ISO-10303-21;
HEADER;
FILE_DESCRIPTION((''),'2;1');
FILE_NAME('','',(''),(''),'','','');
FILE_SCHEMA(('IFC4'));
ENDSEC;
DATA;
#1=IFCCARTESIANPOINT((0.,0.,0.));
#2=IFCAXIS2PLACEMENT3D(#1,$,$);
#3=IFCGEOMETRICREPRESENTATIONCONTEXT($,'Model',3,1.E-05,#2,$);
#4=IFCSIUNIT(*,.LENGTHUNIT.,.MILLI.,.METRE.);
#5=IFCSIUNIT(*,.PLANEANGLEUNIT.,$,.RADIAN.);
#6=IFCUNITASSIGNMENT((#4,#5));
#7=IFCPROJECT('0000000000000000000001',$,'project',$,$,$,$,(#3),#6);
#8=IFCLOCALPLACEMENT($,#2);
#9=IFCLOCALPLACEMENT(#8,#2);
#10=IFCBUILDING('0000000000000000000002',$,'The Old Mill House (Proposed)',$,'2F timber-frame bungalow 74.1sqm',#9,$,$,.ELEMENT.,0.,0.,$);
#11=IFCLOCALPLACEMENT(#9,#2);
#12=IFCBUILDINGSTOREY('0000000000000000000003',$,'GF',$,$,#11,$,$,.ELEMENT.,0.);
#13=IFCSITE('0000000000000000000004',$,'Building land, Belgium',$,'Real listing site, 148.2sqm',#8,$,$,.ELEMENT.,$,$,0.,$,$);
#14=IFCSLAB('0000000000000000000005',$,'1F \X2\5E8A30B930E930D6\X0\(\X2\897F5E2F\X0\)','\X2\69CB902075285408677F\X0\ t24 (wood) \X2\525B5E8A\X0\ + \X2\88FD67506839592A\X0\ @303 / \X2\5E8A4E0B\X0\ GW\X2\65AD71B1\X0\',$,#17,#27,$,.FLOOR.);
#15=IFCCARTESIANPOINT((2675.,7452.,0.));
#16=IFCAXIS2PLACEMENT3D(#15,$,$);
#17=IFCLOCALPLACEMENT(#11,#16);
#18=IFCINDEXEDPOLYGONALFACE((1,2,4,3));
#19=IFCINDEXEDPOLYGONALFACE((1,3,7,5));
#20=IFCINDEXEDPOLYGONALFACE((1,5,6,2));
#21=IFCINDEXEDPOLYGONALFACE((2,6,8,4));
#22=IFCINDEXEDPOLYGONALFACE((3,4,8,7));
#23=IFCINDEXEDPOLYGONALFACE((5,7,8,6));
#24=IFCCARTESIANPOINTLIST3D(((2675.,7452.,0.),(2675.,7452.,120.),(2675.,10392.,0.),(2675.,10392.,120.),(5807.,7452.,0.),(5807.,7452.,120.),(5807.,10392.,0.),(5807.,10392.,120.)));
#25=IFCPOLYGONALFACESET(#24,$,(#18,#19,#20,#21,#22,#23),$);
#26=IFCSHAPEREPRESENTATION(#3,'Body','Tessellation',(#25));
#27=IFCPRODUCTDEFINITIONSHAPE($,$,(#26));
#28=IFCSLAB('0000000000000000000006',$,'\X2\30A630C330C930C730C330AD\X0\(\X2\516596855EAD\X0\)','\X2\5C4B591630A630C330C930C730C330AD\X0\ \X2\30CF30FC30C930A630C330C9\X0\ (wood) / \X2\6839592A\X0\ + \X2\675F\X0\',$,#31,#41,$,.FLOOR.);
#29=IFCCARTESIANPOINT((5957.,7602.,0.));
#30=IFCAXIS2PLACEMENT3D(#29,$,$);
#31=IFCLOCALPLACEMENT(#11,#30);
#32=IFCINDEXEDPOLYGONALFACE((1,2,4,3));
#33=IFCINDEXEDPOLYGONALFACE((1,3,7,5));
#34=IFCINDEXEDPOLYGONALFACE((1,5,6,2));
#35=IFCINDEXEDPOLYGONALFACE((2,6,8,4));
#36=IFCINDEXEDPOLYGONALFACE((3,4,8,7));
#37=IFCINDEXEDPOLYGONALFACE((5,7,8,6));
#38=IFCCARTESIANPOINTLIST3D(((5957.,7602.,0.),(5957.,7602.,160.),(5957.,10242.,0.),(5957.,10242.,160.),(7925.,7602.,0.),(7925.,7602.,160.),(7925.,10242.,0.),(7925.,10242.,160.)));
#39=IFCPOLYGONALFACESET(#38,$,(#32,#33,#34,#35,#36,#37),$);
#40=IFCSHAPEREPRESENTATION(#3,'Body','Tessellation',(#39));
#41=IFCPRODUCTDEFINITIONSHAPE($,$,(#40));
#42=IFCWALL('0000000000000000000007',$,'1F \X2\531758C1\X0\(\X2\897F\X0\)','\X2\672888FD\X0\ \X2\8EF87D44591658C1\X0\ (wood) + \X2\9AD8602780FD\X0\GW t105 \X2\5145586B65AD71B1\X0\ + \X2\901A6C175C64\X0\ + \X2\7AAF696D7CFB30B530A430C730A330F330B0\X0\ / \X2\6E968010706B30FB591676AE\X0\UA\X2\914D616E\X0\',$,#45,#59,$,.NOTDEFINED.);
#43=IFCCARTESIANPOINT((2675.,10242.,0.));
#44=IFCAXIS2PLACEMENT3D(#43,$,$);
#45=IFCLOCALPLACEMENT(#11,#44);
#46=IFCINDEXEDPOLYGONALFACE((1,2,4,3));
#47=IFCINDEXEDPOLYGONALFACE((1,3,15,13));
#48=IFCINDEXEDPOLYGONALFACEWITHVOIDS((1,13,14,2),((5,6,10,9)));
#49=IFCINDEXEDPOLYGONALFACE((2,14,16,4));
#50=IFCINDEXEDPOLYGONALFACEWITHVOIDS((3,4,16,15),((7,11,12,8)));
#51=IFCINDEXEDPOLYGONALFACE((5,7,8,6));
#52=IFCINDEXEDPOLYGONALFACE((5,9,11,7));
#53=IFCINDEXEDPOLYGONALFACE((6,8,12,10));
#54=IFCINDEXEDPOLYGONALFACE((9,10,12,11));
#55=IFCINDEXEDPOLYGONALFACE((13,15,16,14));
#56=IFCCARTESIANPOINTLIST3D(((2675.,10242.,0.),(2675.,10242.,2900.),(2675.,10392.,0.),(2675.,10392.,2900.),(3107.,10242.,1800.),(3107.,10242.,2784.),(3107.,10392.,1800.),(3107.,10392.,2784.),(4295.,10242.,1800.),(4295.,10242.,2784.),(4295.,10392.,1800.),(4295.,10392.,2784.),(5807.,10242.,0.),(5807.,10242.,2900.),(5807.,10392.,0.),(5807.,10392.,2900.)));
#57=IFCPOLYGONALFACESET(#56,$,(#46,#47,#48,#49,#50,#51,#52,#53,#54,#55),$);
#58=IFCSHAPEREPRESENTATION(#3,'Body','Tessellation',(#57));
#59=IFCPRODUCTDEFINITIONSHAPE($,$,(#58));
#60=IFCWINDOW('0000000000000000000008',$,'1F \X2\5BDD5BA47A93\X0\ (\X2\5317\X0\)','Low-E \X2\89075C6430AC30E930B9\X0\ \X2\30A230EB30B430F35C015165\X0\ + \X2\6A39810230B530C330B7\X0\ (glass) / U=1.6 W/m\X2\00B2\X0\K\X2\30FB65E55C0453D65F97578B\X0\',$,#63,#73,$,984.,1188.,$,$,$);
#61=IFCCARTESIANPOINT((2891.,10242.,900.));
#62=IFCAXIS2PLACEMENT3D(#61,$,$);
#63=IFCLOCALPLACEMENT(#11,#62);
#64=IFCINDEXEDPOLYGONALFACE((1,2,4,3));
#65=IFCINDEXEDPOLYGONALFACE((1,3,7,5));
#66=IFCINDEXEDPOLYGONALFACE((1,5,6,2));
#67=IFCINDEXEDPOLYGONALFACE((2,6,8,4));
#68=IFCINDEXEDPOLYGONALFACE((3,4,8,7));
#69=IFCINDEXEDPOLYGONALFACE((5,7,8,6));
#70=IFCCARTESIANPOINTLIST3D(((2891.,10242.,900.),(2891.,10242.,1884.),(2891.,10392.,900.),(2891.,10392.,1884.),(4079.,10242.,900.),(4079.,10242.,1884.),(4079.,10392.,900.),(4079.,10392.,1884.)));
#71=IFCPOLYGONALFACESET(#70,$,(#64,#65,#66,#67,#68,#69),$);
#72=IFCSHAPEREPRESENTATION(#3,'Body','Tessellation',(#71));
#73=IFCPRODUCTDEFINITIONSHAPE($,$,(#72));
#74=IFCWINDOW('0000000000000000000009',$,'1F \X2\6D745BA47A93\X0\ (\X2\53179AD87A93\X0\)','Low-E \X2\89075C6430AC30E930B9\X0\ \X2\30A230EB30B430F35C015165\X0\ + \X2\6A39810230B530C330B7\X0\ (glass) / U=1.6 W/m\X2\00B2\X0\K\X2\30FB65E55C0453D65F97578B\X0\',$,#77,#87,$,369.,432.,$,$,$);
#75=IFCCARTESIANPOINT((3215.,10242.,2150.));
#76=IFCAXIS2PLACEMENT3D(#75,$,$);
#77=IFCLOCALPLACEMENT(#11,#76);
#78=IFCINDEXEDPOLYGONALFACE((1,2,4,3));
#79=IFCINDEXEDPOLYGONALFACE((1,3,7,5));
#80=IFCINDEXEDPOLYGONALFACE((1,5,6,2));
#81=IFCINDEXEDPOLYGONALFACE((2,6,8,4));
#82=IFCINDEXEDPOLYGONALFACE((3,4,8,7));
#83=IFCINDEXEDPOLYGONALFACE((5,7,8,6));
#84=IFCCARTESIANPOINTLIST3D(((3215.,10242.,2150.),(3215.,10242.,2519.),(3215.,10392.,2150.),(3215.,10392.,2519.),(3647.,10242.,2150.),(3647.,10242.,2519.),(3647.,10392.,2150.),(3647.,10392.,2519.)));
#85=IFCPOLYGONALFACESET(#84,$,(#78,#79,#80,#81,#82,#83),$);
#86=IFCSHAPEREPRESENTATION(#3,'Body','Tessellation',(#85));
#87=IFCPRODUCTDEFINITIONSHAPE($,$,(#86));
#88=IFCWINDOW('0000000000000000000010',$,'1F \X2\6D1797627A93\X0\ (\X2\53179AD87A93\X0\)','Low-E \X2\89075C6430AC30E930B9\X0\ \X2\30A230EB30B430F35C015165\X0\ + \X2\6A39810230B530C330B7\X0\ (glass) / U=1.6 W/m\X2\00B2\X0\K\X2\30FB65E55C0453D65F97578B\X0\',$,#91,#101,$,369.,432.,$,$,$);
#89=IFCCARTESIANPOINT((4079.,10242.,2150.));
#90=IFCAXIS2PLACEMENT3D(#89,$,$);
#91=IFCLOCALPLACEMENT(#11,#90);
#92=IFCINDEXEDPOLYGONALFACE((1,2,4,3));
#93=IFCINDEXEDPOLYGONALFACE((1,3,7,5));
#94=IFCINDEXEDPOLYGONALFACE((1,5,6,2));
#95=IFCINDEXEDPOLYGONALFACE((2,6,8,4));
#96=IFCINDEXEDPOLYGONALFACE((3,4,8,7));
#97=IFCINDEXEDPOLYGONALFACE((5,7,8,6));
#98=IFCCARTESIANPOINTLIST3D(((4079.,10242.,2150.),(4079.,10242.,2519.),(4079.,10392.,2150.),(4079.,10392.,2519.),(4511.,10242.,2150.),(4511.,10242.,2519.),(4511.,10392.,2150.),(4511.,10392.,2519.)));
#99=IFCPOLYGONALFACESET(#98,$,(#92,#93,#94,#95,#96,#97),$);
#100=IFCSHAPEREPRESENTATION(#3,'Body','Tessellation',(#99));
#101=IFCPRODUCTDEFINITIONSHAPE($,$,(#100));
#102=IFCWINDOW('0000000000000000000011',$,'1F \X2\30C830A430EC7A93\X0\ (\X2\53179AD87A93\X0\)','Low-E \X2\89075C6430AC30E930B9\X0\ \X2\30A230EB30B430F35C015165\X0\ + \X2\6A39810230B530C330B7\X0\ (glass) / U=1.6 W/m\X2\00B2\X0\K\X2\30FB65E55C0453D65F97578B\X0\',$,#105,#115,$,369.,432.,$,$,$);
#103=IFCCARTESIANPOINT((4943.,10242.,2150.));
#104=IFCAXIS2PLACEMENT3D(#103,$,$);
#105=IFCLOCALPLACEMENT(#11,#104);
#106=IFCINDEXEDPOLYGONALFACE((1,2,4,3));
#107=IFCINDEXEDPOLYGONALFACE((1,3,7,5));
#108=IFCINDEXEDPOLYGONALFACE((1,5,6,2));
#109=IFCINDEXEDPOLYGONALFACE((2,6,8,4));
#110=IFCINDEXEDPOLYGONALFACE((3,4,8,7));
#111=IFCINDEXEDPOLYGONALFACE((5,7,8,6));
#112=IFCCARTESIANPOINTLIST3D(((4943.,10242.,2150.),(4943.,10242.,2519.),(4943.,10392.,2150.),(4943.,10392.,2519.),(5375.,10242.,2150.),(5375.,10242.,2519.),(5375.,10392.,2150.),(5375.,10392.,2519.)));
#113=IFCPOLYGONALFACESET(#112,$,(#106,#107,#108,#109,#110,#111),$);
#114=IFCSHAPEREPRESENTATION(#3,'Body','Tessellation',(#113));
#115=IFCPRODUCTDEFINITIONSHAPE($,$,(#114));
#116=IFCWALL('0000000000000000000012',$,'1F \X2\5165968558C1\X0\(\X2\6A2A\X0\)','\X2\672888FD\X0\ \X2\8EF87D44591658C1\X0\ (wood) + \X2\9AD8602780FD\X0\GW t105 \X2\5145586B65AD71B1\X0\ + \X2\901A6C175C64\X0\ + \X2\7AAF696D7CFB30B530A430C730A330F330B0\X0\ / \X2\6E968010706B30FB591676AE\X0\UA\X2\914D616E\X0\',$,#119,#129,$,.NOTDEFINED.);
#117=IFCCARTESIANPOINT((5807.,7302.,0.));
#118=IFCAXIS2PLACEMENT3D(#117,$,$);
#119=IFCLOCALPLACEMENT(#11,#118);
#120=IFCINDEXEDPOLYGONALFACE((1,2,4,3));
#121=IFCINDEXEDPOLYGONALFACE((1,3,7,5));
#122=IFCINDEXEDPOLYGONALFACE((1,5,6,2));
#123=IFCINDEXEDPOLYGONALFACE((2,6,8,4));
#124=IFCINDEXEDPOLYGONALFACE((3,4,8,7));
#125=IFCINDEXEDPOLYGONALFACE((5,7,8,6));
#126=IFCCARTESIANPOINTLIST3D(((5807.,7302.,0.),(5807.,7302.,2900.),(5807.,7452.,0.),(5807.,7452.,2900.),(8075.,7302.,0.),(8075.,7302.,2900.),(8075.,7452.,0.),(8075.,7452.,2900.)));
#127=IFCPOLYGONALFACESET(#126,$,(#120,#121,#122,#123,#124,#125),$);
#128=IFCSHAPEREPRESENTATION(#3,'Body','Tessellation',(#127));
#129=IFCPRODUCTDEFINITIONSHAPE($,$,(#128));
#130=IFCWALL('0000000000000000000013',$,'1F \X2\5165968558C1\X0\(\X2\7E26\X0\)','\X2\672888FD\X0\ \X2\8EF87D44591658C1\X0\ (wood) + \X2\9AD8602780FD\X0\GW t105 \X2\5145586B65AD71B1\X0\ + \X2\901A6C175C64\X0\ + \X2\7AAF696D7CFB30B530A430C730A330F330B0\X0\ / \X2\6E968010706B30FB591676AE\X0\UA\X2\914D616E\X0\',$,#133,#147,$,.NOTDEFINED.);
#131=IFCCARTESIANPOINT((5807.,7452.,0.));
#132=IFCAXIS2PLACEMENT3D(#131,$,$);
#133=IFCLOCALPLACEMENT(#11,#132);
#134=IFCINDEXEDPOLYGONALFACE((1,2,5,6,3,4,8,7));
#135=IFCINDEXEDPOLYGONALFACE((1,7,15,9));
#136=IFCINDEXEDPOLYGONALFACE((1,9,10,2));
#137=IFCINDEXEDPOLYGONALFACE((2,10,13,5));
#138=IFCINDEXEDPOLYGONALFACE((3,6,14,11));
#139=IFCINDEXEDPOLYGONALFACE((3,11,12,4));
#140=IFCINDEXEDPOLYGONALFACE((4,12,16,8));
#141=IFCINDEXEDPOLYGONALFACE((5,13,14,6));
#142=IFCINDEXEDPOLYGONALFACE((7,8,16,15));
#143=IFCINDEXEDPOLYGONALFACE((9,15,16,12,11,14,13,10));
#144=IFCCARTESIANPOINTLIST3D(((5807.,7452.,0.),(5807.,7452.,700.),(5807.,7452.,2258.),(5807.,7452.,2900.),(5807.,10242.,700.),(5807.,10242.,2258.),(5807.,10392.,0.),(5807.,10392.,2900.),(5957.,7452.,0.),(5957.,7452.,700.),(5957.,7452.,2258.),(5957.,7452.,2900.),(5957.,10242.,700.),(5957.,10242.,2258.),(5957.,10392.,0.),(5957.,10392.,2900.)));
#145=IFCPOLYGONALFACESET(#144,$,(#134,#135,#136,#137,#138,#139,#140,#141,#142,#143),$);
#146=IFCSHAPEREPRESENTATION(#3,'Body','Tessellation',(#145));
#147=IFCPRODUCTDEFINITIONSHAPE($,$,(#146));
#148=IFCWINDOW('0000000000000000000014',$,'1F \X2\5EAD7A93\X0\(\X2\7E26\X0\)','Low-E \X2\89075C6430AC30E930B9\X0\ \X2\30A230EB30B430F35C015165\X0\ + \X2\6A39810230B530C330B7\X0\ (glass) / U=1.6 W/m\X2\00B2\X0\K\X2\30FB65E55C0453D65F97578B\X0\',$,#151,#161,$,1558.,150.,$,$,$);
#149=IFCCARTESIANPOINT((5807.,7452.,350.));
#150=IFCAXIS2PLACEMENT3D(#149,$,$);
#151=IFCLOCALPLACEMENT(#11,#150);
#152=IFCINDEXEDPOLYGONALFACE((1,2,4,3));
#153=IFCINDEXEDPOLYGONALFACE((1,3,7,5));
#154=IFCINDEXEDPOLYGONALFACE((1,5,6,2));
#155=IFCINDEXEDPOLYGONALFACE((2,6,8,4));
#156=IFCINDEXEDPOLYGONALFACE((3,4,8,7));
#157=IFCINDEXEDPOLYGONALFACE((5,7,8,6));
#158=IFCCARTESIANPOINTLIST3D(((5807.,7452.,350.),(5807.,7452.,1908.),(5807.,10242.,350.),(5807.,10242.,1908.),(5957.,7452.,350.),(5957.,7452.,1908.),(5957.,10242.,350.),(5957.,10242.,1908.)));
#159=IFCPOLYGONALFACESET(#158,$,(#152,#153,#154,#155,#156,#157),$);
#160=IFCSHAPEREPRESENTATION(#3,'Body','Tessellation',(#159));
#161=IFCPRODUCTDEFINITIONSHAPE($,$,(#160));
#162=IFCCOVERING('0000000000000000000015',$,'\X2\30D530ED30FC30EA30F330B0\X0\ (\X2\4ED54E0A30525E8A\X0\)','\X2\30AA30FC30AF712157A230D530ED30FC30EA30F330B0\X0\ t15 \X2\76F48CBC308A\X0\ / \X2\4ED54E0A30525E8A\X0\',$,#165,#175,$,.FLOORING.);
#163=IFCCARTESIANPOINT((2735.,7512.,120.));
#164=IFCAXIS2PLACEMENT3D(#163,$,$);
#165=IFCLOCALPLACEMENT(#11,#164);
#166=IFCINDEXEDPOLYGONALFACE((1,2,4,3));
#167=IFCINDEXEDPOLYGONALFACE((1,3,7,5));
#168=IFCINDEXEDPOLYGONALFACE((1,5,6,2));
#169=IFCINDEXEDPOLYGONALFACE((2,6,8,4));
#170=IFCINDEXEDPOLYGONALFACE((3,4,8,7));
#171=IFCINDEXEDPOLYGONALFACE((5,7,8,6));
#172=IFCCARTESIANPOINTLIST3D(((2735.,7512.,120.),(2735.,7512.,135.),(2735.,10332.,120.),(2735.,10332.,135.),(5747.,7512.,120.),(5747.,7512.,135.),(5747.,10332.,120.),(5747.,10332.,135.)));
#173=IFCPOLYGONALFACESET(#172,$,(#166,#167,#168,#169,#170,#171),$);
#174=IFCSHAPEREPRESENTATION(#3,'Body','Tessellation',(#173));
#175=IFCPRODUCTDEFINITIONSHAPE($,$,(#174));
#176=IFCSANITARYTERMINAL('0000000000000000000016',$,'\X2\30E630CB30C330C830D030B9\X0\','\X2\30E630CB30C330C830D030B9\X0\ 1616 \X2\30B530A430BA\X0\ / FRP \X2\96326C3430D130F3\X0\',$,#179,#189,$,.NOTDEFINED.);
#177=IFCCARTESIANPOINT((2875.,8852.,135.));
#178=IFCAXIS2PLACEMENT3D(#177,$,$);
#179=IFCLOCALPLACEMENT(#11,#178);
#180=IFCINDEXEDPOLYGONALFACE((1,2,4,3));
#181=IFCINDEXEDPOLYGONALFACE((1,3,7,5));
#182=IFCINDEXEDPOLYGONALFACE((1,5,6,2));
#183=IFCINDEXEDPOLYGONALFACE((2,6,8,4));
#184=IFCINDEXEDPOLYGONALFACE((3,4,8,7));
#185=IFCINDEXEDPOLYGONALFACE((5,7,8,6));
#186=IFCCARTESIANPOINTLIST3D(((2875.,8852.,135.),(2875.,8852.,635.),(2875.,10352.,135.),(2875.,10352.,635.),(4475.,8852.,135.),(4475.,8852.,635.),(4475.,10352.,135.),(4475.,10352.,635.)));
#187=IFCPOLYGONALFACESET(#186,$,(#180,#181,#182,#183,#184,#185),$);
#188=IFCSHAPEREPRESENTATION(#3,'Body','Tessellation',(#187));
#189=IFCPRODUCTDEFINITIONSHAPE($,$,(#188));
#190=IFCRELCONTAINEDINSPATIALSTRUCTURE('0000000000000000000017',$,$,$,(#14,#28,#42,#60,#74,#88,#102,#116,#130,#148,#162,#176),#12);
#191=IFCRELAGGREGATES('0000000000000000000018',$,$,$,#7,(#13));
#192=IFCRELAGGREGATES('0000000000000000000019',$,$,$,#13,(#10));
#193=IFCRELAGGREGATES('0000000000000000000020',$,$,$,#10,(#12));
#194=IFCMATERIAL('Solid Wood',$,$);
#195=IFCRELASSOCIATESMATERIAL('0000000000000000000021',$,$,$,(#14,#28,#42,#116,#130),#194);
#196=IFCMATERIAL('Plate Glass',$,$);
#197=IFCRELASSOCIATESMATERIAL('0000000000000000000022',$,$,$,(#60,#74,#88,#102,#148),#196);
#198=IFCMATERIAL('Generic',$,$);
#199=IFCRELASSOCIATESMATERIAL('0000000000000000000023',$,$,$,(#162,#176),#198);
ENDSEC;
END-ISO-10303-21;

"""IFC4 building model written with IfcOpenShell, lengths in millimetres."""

from ifc_helpers import new_model, si_unit, frame, frame_2d, origin, place, context, project, spatial, rectangle, extrude, material, element, fill, save


model = new_model("IFC4")

# Units and contexts
model_context = context("Model", 3, precision=1e-05, world=origin())
ifc_project = project(units=[si_unit("LENGTHUNIT", "METRE", prefix="MILLI"), si_unit("PLANEANGLEUNIT", "RADIAN")], contexts=[model_context])

# Site, building, storey
site_placement = place(None, origin())
site = spatial("IfcSite", under=ifc_project, at=site_placement, Name="Building land, Belgium", ObjectType="Real listing site, 148.2sqm", CompositionType="ELEMENT", RefElevation=0.0)
building_placement = place(site_placement, origin())
building = spatial("IfcBuilding", under=site, at=building_placement, Name="The Old Mill House (Proposed)", ObjectType="2F timber-frame bungalow 74.1sqm", CompositionType="ELEMENT", ElevationOfRefHeight=0.0, ElevationOfTerrain=0.0)
storey_placement = place(building_placement, origin())
storey = spatial("IfcBuildingStorey", under=building, at=storey_placement, Name="GF", CompositionType="ELEMENT", Elevation=0.0)

# Slabs
ifc_material_1 = material(Name="Solid Wood")
slab_1_placement = place(storey_placement, frame((2675.0, 7452.0, 0.0)))
element("IfcSlab", 1, at=slab_1_placement, inside=storey, material=ifc_material_1, Name="1F 床スラブ(西帯)", Description="構造用合板 t24 (wood) 剛床 + 製材根太 @303 / 床下 GW断熱", PredefinedType="FLOOR", context=model_context, shape_type="SweptSolid", body=[
    extrude(rectangle(XDim=3132.0, YDim=2940.0, at=frame_2d((1566.0, 1470.0))), frame((2675.0, 7452.0, 0.0)), (0.0, 0.0, 1.0), 120.0),
])
slab_2_placement = place(storey_placement, frame((5957.0, 7602.0, 0.0)))
element("IfcSlab", 2, at=slab_2_placement, inside=storey, material=ifc_material_1, Name="ウッドデッキ(入隅庭)", Description="屋外ウッドデッキ ハードウッド (wood) / 根太 + 束", PredefinedType="FLOOR", context=model_context, shape_type="SweptSolid", body=[
    extrude(rectangle(XDim=1968.0, YDim=2640.0, at=frame_2d((984.0, 1320.0))), frame((5957.0, 7602.0, 0.0)), (0.0, 0.0, 1.0), 160.0),
])

# Wall, openings, windows
wall_1_placement = place(storey_placement, frame((2675.0, 10242.0, 0.0)))
wall_1 = element("IfcWall", 3, at=wall_1_placement, inside=storey, material=ifc_material_1, Name="1F 北壁(西)", Description="木製 軸組外壁 (wood) + 高性能GW t105 充填断熱 + 通気層 + 窯業系サイディング / 準耐火・外皮UA配慮", PredefinedType="NOTDEFINED", context=model_context, shape_type="SweptSolid", body=[
    extrude(rectangle(XDim=3132.0, YDim=150.0, at=frame_2d((1566.0, 75.0))), frame((2675.0, 10242.0, 0.0)), (0.0, 0.0, 1.0), 2900.0),
])
opening_1_placement = place(storey_placement, frame((2891.0, 10242.0, 900.0)))
opening_1 = element("IfcOpeningElement", 4, at=opening_1_placement, cuts=wall_1, PredefinedType="NOTDEFINED", context=model_context, shape_type="SweptSolid", body=[
    extrude(rectangle(XDim=1188.0, YDim=150.0, at=frame_2d((594.0, 75.0))), frame((2891.0, 10242.0, 900.0)), (0.0, 0.0, 1.0), 984.0),
])
opening_2_placement = place(storey_placement, frame((3215.0, 10242.0, 2150.0)))
opening_2 = element("IfcOpeningElement", 5, at=opening_2_placement, cuts=wall_1, PredefinedType="NOTDEFINED", context=model_context, shape_type="SweptSolid", body=[
    extrude(rectangle(XDim=432.0, YDim=150.0, at=frame_2d((216.0, 75.0))), frame((3215.0, 10242.0, 2150.0)), (0.0, 0.0, 1.0), 369.0),
])
opening_3_placement = place(storey_placement, frame((4079.0, 10242.0, 2150.0)))
opening_3 = element("IfcOpeningElement", 6, at=opening_3_placement, cuts=wall_1, PredefinedType="NOTDEFINED", context=model_context, shape_type="SweptSolid", body=[
    extrude(rectangle(XDim=432.0, YDim=150.0, at=frame_2d((216.0, 75.0))), frame((4079.0, 10242.0, 2150.0)), (0.0, 0.0, 1.0), 369.0),
])
opening_4_placement = place(storey_placement, frame((4943.0, 10242.0, 2150.0)))
opening_4 = element("IfcOpeningElement", 7, at=opening_4_placement, cuts=wall_1, PredefinedType="NOTDEFINED", context=model_context, shape_type="SweptSolid", body=[
    extrude(rectangle(XDim=432.0, YDim=150.0, at=frame_2d((216.0, 75.0))), frame((4943.0, 10242.0, 2150.0)), (0.0, 0.0, 1.0), 369.0),
])
ifc_material_2 = material(Name="Plate Glass")
window_1_placement = place(storey_placement, frame((2891.0, 10242.0, 900.0)))
window_1 = element("IfcWindow", 8, at=window_1_placement, inside=storey, material=ifc_material_2, Name="1F 寝室窓 (北)", Description="Low-E 複層ガラス アルゴン封入 + 樹脂サッシ (glass) / U=1.6 W/m²K・日射取得型", OverallHeight=984.0, OverallWidth=1188.0, context=model_context, shape_type="SweptSolid", body=[
    extrude(rectangle(XDim=1188.0, YDim=150.0, at=frame_2d((594.0, 75.0))), frame((2891.0, 10242.0, 900.0)), (0.0, 0.0, 1.0), 984.0),
])
fill(opening_1, window_1)
window_2_placement = place(storey_placement, frame((3215.0, 10242.0, 2150.0)))
window_2 = element("IfcWindow", 9, at=window_2_placement, inside=storey, material=ifc_material_2, Name="1F 浴室窓 (北高窓)", Description="Low-E 複層ガラス アルゴン封入 + 樹脂サッシ (glass) / U=1.6 W/m²K・日射取得型", OverallHeight=369.0, OverallWidth=432.0, context=model_context, shape_type="SweptSolid", body=[
    extrude(rectangle(XDim=432.0, YDim=150.0, at=frame_2d((216.0, 75.0))), frame((3215.0, 10242.0, 2150.0)), (0.0, 0.0, 1.0), 369.0),
])
fill(opening_2, window_2)
window_3_placement = place(storey_placement, frame((4079.0, 10242.0, 2150.0)))
window_3 = element("IfcWindow", 10, at=window_3_placement, inside=storey, material=ifc_material_2, Name="1F 洗面窓 (北高窓)", Description="Low-E 複層ガラス アルゴン封入 + 樹脂サッシ (glass) / U=1.6 W/m²K・日射取得型", OverallHeight=369.0, OverallWidth=432.0, context=model_context, shape_type="SweptSolid", body=[
    extrude(rectangle(XDim=432.0, YDim=150.0, at=frame_2d((216.0, 75.0))), frame((4079.0, 10242.0, 2150.0)), (0.0, 0.0, 1.0), 369.0),
])
fill(opening_3, window_3)
window_4_placement = place(storey_placement, frame((4943.0, 10242.0, 2150.0)))
window_4 = element("IfcWindow", 11, at=window_4_placement, inside=storey, material=ifc_material_2, Name="1F トイレ窓 (北高窓)", Description="Low-E 複層ガラス アルゴン封入 + 樹脂サッシ (glass) / U=1.6 W/m²K・日射取得型", OverallHeight=369.0, OverallWidth=432.0, context=model_context, shape_type="SweptSolid", body=[
    extrude(rectangle(XDim=432.0, YDim=150.0, at=frame_2d((216.0, 75.0))), frame((4943.0, 10242.0, 2150.0)), (0.0, 0.0, 1.0), 369.0),
])
fill(opening_4, window_4)

# Wall
wall_2_placement = place(storey_placement, frame((5807.0, 7302.0, 0.0)))
element("IfcWall", 12, at=wall_2_placement, inside=storey, material=ifc_material_1, Name="1F 入隅壁(横)", Description="木製 軸組外壁 (wood) + 高性能GW t105 充填断熱 + 通気層 + 窯業系サイディング / 準耐火・外皮UA配慮", PredefinedType="NOTDEFINED", context=model_context, shape_type="SweptSolid", body=[
    extrude(rectangle(XDim=2268.0, YDim=150.0, at=frame_2d((1134.0, 75.0))), frame((5807.0, 7302.0, 0.0)), (0.0, 0.0, 1.0), 2900.0),
])

# Wall, opening, window
wall_3_placement = place(storey_placement, frame((5807.0, 7452.0, 0.0)))
wall_3 = element("IfcWall", 13, at=wall_3_placement, inside=storey, material=ifc_material_1, Name="1F 入隅壁(縦)", Description="木製 軸組外壁 (wood) + 高性能GW t105 充填断熱 + 通気層 + 窯業系サイディング / 準耐火・外皮UA配慮", PredefinedType="NOTDEFINED", context=model_context, shape_type="SweptSolid", body=[
    extrude(rectangle(XDim=150.0, YDim=2940.0, at=frame_2d((75.0, 1470.0))), frame((5807.0, 7452.0, 0.0)), (0.0, 0.0, 1.0), 2900.0),
])
opening_5_placement = place(storey_placement, frame((5807.0, 7452.0, 350.0)))
opening_5 = element("IfcOpeningElement", 14, at=opening_5_placement, cuts=wall_3, PredefinedType="NOTDEFINED", context=model_context, shape_type="SweptSolid", body=[
    extrude(rectangle(XDim=150.0, YDim=2790.0, at=frame_2d((75.0, 1395.0))), frame((5807.0, 7452.0, 350.0)), (0.0, 0.0, 1.0), 1558.0),
])
window_5_placement = place(storey_placement, frame((5807.0, 7452.0, 350.0)))
window_5 = element("IfcWindow", 15, at=window_5_placement, inside=storey, material=ifc_material_2, Name="1F 庭窓(縦)", Description="Low-E 複層ガラス アルゴン封入 + 樹脂サッシ (glass) / U=1.6 W/m²K・日射取得型", OverallHeight=1558.0, OverallWidth=150.0, context=model_context, shape_type="SweptSolid", body=[
    extrude(rectangle(XDim=150.0, YDim=2790.0, at=frame_2d((75.0, 1395.0))), frame((5807.0, 7452.0, 350.0)), (0.0, 0.0, 1.0), 1558.0),
])
fill(opening_5, window_5)

# Covering
ifc_material_3 = material(Name="Generic")
covering_placement = place(storey_placement, frame((2735.0, 7512.0, 120.0)))
element("IfcCovering", 16, at=covering_placement, inside=storey, material=ifc_material_3, Name="フローリング (仕上げ床)", Description="オーク無垢フローリング t15 直貼り / 仕上げ床", PredefinedType="FLOORING", context=model_context, shape_type="SweptSolid", body=[
    extrude(rectangle(XDim=3012.0, YDim=2820.0, at=frame_2d((1506.0, 1410.0))), frame((2735.0, 7512.0, 120.0)), (0.0, 0.0, 1.0), 15.0),
])

# Sanitary terminal
sanitary_terminal_1_placement = place(storey_placement, frame((2875.0, 8852.0, 135.0)))
element("IfcSanitaryTerminal", 17, at=sanitary_terminal_1_placement, inside=storey, material=ifc_material_3, Name="ユニットバス", Description="ユニットバス 1616 サイズ / FRP 防水パン", PredefinedType="NOTDEFINED", context=model_context, shape_type="SweptSolid", body=[
    extrude(rectangle(XDim=1600.0, YDim=1500.0, at=frame_2d((800.0, 750.0))), frame((2875.0, 8852.0, 135.0)), (0.0, 0.0, 1.0), 500.0),
])

save(model, "model.ifc")
